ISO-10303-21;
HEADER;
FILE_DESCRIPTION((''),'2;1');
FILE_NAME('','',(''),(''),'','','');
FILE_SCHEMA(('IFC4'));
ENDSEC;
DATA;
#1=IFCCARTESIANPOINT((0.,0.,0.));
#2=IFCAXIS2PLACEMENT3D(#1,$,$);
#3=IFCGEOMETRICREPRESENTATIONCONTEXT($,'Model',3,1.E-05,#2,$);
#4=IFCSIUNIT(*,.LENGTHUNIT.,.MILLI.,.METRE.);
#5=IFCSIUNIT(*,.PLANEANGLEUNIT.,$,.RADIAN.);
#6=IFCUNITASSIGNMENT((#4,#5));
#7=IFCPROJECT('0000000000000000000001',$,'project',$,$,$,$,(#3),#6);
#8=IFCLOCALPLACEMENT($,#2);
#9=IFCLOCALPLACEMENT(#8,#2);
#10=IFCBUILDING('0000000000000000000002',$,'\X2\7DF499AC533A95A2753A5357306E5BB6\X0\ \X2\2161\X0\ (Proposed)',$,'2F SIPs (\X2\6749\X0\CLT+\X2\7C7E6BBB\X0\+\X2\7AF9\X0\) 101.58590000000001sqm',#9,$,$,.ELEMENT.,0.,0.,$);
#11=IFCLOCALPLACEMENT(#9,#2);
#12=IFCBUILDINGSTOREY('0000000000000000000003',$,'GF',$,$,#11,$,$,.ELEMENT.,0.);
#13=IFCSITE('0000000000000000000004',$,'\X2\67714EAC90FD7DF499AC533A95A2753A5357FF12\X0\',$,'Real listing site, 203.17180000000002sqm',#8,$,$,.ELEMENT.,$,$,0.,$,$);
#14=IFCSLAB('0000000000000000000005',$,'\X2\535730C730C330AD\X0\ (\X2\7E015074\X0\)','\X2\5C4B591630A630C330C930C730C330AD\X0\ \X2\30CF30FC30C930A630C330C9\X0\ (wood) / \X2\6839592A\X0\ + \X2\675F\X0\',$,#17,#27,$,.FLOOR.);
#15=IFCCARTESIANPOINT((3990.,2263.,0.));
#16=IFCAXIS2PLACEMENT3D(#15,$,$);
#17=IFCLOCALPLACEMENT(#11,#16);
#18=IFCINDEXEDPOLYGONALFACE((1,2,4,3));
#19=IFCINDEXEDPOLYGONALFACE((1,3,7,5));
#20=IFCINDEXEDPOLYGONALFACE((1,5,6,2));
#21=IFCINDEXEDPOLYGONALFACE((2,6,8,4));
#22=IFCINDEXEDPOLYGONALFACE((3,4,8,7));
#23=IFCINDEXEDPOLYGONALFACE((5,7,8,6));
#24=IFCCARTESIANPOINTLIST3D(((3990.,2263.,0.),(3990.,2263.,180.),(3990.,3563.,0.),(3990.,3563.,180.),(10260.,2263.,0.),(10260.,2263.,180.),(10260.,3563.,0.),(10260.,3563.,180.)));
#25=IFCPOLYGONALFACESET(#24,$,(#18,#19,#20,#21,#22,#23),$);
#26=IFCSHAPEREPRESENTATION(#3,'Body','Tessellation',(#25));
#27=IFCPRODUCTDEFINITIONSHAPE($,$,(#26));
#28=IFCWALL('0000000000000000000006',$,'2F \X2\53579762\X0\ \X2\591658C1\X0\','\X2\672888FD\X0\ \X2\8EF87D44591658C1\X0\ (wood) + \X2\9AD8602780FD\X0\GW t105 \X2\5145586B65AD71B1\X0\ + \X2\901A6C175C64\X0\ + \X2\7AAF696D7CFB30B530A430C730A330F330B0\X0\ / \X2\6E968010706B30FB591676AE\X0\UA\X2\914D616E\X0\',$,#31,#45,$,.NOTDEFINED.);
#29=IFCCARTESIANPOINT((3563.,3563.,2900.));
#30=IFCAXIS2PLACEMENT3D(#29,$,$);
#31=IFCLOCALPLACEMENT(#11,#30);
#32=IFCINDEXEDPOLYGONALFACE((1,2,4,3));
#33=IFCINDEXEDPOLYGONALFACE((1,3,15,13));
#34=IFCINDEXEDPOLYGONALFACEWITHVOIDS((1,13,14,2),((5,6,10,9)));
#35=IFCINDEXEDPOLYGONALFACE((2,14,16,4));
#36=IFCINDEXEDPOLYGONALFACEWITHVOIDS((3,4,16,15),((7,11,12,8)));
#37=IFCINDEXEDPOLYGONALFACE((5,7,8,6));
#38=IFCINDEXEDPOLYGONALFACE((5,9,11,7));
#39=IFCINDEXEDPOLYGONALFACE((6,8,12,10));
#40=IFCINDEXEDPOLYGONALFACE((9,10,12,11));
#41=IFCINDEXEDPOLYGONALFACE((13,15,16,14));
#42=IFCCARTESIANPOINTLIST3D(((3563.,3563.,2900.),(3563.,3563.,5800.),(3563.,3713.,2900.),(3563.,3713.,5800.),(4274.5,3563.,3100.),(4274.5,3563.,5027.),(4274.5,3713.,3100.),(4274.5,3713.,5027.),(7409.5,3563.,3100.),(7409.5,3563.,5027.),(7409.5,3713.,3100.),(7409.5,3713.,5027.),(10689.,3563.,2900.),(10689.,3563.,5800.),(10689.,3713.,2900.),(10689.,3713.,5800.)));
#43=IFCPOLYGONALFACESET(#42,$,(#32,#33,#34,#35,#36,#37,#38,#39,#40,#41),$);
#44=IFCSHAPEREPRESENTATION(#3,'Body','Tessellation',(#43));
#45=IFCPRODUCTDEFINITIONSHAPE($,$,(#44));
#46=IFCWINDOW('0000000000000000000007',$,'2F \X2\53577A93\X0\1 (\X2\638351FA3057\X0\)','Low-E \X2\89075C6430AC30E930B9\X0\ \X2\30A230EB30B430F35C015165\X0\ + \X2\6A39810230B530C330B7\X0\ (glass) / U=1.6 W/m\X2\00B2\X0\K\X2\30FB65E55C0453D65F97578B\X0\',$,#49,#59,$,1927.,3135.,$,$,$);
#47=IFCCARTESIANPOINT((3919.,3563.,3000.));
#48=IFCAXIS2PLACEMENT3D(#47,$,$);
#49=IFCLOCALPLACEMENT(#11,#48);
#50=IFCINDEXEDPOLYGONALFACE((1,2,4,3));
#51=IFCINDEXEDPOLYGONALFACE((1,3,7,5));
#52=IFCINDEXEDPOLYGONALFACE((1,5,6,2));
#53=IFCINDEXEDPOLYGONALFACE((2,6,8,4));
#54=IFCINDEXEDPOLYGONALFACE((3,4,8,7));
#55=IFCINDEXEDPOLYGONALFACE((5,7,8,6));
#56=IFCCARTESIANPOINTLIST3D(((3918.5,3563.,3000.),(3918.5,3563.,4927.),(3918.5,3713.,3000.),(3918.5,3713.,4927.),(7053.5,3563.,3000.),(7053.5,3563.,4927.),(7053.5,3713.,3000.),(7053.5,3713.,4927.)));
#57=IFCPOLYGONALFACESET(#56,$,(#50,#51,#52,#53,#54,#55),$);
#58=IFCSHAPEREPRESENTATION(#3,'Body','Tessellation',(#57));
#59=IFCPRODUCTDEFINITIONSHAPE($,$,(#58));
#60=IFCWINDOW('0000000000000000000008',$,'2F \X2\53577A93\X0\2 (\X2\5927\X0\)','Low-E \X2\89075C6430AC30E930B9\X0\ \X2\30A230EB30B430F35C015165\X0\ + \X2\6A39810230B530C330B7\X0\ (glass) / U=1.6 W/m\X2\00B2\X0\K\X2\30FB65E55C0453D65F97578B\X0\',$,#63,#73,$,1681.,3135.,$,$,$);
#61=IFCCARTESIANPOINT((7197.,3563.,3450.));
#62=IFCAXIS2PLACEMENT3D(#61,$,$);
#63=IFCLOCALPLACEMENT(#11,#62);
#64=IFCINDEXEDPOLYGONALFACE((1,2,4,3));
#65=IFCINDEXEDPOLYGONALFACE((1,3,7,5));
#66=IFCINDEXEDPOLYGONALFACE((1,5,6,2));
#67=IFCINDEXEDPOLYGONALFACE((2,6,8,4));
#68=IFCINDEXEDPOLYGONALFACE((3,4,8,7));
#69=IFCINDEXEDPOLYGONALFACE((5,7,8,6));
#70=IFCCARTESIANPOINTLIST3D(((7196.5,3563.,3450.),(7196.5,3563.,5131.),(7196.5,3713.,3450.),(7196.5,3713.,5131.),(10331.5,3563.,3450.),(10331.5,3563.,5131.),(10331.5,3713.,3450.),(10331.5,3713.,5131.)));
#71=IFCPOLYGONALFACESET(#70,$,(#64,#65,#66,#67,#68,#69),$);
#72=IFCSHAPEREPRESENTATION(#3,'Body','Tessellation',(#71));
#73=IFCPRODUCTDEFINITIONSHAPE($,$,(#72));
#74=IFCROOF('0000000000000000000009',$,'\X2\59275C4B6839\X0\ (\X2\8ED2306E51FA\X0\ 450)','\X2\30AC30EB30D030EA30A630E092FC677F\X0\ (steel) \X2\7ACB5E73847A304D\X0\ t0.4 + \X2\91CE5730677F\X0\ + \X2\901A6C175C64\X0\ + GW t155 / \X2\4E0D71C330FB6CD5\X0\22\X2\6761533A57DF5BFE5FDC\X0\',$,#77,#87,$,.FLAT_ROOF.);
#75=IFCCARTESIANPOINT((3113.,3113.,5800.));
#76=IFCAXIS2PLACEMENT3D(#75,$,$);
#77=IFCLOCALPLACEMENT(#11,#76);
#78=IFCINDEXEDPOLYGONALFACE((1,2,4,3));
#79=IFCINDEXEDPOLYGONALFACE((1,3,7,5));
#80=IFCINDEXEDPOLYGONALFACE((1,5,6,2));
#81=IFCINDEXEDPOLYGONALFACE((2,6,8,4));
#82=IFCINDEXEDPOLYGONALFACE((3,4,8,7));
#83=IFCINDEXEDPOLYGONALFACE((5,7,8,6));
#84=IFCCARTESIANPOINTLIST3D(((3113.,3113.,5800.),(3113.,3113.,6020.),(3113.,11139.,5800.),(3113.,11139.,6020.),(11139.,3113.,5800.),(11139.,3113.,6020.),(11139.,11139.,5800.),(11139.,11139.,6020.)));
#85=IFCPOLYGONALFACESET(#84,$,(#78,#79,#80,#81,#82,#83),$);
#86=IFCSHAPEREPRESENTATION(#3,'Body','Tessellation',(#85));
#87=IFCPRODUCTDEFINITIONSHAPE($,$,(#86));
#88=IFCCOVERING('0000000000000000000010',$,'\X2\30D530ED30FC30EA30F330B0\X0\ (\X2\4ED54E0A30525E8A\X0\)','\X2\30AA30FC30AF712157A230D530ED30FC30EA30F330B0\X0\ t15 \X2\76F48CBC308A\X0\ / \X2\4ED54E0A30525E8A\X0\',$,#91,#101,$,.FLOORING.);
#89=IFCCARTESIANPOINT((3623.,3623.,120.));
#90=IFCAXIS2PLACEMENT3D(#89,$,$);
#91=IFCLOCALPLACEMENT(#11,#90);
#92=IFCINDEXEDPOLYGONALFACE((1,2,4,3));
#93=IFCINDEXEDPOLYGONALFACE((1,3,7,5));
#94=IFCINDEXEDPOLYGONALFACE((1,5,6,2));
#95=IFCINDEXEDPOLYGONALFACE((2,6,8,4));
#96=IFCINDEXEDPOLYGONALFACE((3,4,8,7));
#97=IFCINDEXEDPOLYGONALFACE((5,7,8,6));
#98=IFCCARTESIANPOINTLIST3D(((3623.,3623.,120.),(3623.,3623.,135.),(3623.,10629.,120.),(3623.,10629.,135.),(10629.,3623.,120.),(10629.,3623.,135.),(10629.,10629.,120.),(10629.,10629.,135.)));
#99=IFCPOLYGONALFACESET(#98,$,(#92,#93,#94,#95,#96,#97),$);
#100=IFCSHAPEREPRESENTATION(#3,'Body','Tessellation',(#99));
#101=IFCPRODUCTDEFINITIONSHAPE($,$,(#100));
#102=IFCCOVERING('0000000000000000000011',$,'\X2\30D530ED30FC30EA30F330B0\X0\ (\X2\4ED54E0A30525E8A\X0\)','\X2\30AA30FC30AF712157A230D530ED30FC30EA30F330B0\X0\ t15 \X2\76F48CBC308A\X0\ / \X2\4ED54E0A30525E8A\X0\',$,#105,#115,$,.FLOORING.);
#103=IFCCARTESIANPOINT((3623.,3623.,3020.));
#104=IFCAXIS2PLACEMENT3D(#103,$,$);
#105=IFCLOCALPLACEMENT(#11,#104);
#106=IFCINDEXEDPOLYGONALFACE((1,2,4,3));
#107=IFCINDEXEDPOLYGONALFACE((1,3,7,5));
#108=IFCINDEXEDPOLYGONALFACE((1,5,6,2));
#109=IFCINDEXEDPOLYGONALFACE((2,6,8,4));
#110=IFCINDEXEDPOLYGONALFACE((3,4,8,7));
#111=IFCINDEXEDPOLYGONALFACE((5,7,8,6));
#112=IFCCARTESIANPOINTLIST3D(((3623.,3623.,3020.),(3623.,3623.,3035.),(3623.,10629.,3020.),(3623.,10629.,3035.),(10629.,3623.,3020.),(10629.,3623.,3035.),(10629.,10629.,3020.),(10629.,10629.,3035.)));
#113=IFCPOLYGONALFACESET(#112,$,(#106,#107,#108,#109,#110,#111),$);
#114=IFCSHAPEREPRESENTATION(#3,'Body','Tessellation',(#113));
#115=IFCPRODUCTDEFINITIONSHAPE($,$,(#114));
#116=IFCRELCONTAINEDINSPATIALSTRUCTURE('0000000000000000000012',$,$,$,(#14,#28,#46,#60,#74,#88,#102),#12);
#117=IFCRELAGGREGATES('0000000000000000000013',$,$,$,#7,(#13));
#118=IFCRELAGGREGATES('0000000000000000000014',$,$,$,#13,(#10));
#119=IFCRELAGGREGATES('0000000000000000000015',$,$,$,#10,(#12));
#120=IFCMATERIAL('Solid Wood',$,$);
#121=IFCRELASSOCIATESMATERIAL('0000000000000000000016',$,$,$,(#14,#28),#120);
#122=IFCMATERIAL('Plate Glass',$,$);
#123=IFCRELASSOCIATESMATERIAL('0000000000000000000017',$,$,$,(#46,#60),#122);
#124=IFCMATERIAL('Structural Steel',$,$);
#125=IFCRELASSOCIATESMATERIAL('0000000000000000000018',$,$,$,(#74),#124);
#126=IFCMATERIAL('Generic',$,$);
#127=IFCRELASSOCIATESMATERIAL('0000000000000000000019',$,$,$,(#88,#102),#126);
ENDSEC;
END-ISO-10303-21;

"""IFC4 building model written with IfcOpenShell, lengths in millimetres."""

from ifc_helpers import new_model, si_unit, frame, frame_2d, origin, place, context, project, spatial, rectangle, extrude, material, element, fill, save


model = new_model("IFC4")

# Units and contexts
model_context = context("Model", 3, precision=1e-05, world=origin())
ifc_project = project(units=[si_unit("LENGTHUNIT", "METRE", prefix="MILLI"), si_unit("PLANEANGLEUNIT", "RADIAN")], contexts=[model_context])

# Site, building, storey
site_placement = place(None, origin())
site = spatial("IfcSite", under=ifc_project, at=site_placement, Name="東京都練馬区関町南２", ObjectType="Real listing site, 203.17180000000002sqm", CompositionType="ELEMENT", RefElevation=0.0)
building_placement = place(site_placement, origin())
building = spatial("IfcBuilding", under=site, at=building_placement, Name="練馬区関町南の家 Ⅱ (Proposed)", ObjectType="2F SIPs (杉CLT+籾殻+竹) 101.58590000000001sqm", CompositionType="ELEMENT", ElevationOfRefHeight=0.0, ElevationOfTerrain=0.0)
storey_placement = place(building_placement, origin())
storey = spatial("IfcBuildingStorey", under=building, at=storey_placement, Name="GF", CompositionType="ELEMENT", Elevation=0.0)

# Slab
ifc_material_1 = material(Name="Solid Wood")
slab_1_placement = place(storey_placement, frame((3990.0, 2263.0, 0.0)))
element("IfcSlab", 1, at=slab_1_placement, inside=storey, material=ifc_material_1, Name="南デッキ (縁側)", Description="屋外ウッドデッキ ハードウッド (wood) / 根太 + 束", PredefinedType="FLOOR", context=model_context, shape_type="SweptSolid", body=[
    extrude(rectangle(XDim=6270.0, YDim=1300.0, at=frame_2d((3135.0, 650.0))), frame((3990.0, 2263.0, 0.0)), (0.0, 0.0, 1.0), 180.0),
])

# Shared definitions
ifc_material_2 = material(Name="Plate Glass")

# Wall, openings, windows
wall_1_placement = place(storey_placement, frame((3563.0, 3563.0, 2900.0)))
wall_1 = element("IfcWall", 2, at=wall_1_placement, inside=storey, material=ifc_material_1, Name="2F 南面 外壁", Description="木製 軸組外壁 (wood) + 高性能GW t105 充填断熱 + 通気層 + 窯業系サイディング / 準耐火・外皮UA配慮", PredefinedType="NOTDEFINED", context=model_context, shape_type="SweptSolid", body=[
    extrude(rectangle(XDim=7126.0, YDim=150.0, at=frame_2d((3563.0, 75.0))), frame((3563.0, 3563.0, 2900.0)), (0.0, 0.0, 1.0), 2900.0),
])
opening_1_placement = place(storey_placement, frame((3919.0, 3563.0, 3000.0)))
opening_1 = element("IfcOpeningElement", 3, at=opening_1_placement, cuts=wall_1, PredefinedType="NOTDEFINED", context=model_context, shape_type="SweptSolid", body=[
    extrude(rectangle(XDim=3135.0, YDim=150.0, at=frame_2d((1567.0, 75.0))), frame((3919.0, 3563.0, 3000.0)), (0.0, 0.0, 1.0), 1927.0),
])
opening_2_placement = place(storey_placement, frame((7197.0, 3563.0, 3450.0)))
opening_2 = element("IfcOpeningElement", 4, at=opening_2_placement, cuts=wall_1, PredefinedType="NOTDEFINED", context=model_context, shape_type="SweptSolid", body=[
    extrude(rectangle(XDim=3135.0, YDim=150.0, at=frame_2d((1567.0, 75.0))), frame((7197.0, 3563.0, 3450.0)), (0.0, 0.0, 1.0), 1681.0),
])
window_1_placement = place(storey_placement, frame((3919.0, 3563.0, 3000.0)))
window_1 = element("IfcWindow", 5, at=window_1_placement, inside=storey, material=ifc_material_2, Name="2F 南窓1 (掃出し)", Description="Low-E 複層ガラス アルゴン封入 + 樹脂サッシ (glass) / U=1.6 W/m²K・日射取得型", OverallHeight=1927.0, OverallWidth=3135.0, context=model_context, shape_type="SweptSolid", body=[
    extrude(rectangle(XDim=3135.0, YDim=150.0, at=frame_2d((1567.0, 75.0))), frame((3919.0, 3563.0, 3000.0)), (0.0, 0.0, 1.0), 1927.0),
])
fill(opening_1, window_1)
window_2_placement = place(storey_placement, frame((7197.0, 3563.0, 3450.0)))
window_2 = element("IfcWindow", 6, at=window_2_placement, inside=storey, material=ifc_material_2, Name="2F 南窓2 (大)", Description="Low-E 複層ガラス アルゴン封入 + 樹脂サッシ (glass) / U=1.6 W/m²K・日射取得型", OverallHeight=1681.0, OverallWidth=3135.0, context=model_context, shape_type="SweptSolid", body=[
    extrude(rectangle(XDim=3135.0, YDim=150.0, at=frame_2d((1567.0, 75.0))), frame((7197.0, 3563.0, 3450.0)), (0.0, 0.0, 1.0), 1681.0),
])
fill(opening_2, window_2)

# Roof
ifc_material_3 = material(Name="Structural Steel")
roof_placement = place(storey_placement, frame((3113.0, 3113.0, 5800.0)))
element("IfcRoof", 7, at=roof_placement, inside=storey, material=ifc_material_3, Name="大屋根 (軒の出 450)", Description="ガルバリウム鋼板 (steel) 立平葺き t0.4 + 野地板 + 通気層 + GW t155 / 不燃・法22条区域対応", PredefinedType="FLAT_ROOF", context=model_context, shape_type="SweptSolid", body=[
    extrude(rectangle(XDim=8026.0, YDim=8026.0, at=frame_2d((4013.0, 4013.0))), frame((3113.0, 3113.0, 5800.0)), (0.0, 0.0, 1.0), 220.0),
])

# Coverings
ifc_material_4 = material(Name="Generic")
covering_1_placement = place(storey_placement, frame((3623.0, 3623.0, 120.0)))
element("IfcCovering", 8, at=covering_1_placement, inside=storey, material=ifc_material_4, Name="フローリング (仕上げ床)", Description="オーク無垢フローリング t15 直貼り / 仕上げ床", PredefinedType="FLOORING", context=model_context, shape_type="SweptSolid", body=[
    extrude(rectangle(XDim=7006.0, YDim=7006.0, at=frame_2d((3503.0, 3503.0))), frame((3623.0, 3623.0, 120.0)), (0.0, 0.0, 1.0), 15.0),
])
covering_2_placement = place(storey_placement, frame((3623.0, 3623.0, 3020.0)))
element("IfcCovering", 9, at=covering_2_placement, inside=storey, material=ifc_material_4, Name="フローリング (仕上げ床)", Description="オーク無垢フローリング t15 直貼り / 仕上げ床", PredefinedType="FLOORING", context=model_context, shape_type="SweptSolid", body=[
    extrude(rectangle(XDim=7006.0, YDim=7006.0, at=frame_2d((3503.0, 3503.0))), frame((3623.0, 3623.0, 3020.0)), (0.0, 0.0, 1.0), 15.0),
])

save(model, "model.ifc")
